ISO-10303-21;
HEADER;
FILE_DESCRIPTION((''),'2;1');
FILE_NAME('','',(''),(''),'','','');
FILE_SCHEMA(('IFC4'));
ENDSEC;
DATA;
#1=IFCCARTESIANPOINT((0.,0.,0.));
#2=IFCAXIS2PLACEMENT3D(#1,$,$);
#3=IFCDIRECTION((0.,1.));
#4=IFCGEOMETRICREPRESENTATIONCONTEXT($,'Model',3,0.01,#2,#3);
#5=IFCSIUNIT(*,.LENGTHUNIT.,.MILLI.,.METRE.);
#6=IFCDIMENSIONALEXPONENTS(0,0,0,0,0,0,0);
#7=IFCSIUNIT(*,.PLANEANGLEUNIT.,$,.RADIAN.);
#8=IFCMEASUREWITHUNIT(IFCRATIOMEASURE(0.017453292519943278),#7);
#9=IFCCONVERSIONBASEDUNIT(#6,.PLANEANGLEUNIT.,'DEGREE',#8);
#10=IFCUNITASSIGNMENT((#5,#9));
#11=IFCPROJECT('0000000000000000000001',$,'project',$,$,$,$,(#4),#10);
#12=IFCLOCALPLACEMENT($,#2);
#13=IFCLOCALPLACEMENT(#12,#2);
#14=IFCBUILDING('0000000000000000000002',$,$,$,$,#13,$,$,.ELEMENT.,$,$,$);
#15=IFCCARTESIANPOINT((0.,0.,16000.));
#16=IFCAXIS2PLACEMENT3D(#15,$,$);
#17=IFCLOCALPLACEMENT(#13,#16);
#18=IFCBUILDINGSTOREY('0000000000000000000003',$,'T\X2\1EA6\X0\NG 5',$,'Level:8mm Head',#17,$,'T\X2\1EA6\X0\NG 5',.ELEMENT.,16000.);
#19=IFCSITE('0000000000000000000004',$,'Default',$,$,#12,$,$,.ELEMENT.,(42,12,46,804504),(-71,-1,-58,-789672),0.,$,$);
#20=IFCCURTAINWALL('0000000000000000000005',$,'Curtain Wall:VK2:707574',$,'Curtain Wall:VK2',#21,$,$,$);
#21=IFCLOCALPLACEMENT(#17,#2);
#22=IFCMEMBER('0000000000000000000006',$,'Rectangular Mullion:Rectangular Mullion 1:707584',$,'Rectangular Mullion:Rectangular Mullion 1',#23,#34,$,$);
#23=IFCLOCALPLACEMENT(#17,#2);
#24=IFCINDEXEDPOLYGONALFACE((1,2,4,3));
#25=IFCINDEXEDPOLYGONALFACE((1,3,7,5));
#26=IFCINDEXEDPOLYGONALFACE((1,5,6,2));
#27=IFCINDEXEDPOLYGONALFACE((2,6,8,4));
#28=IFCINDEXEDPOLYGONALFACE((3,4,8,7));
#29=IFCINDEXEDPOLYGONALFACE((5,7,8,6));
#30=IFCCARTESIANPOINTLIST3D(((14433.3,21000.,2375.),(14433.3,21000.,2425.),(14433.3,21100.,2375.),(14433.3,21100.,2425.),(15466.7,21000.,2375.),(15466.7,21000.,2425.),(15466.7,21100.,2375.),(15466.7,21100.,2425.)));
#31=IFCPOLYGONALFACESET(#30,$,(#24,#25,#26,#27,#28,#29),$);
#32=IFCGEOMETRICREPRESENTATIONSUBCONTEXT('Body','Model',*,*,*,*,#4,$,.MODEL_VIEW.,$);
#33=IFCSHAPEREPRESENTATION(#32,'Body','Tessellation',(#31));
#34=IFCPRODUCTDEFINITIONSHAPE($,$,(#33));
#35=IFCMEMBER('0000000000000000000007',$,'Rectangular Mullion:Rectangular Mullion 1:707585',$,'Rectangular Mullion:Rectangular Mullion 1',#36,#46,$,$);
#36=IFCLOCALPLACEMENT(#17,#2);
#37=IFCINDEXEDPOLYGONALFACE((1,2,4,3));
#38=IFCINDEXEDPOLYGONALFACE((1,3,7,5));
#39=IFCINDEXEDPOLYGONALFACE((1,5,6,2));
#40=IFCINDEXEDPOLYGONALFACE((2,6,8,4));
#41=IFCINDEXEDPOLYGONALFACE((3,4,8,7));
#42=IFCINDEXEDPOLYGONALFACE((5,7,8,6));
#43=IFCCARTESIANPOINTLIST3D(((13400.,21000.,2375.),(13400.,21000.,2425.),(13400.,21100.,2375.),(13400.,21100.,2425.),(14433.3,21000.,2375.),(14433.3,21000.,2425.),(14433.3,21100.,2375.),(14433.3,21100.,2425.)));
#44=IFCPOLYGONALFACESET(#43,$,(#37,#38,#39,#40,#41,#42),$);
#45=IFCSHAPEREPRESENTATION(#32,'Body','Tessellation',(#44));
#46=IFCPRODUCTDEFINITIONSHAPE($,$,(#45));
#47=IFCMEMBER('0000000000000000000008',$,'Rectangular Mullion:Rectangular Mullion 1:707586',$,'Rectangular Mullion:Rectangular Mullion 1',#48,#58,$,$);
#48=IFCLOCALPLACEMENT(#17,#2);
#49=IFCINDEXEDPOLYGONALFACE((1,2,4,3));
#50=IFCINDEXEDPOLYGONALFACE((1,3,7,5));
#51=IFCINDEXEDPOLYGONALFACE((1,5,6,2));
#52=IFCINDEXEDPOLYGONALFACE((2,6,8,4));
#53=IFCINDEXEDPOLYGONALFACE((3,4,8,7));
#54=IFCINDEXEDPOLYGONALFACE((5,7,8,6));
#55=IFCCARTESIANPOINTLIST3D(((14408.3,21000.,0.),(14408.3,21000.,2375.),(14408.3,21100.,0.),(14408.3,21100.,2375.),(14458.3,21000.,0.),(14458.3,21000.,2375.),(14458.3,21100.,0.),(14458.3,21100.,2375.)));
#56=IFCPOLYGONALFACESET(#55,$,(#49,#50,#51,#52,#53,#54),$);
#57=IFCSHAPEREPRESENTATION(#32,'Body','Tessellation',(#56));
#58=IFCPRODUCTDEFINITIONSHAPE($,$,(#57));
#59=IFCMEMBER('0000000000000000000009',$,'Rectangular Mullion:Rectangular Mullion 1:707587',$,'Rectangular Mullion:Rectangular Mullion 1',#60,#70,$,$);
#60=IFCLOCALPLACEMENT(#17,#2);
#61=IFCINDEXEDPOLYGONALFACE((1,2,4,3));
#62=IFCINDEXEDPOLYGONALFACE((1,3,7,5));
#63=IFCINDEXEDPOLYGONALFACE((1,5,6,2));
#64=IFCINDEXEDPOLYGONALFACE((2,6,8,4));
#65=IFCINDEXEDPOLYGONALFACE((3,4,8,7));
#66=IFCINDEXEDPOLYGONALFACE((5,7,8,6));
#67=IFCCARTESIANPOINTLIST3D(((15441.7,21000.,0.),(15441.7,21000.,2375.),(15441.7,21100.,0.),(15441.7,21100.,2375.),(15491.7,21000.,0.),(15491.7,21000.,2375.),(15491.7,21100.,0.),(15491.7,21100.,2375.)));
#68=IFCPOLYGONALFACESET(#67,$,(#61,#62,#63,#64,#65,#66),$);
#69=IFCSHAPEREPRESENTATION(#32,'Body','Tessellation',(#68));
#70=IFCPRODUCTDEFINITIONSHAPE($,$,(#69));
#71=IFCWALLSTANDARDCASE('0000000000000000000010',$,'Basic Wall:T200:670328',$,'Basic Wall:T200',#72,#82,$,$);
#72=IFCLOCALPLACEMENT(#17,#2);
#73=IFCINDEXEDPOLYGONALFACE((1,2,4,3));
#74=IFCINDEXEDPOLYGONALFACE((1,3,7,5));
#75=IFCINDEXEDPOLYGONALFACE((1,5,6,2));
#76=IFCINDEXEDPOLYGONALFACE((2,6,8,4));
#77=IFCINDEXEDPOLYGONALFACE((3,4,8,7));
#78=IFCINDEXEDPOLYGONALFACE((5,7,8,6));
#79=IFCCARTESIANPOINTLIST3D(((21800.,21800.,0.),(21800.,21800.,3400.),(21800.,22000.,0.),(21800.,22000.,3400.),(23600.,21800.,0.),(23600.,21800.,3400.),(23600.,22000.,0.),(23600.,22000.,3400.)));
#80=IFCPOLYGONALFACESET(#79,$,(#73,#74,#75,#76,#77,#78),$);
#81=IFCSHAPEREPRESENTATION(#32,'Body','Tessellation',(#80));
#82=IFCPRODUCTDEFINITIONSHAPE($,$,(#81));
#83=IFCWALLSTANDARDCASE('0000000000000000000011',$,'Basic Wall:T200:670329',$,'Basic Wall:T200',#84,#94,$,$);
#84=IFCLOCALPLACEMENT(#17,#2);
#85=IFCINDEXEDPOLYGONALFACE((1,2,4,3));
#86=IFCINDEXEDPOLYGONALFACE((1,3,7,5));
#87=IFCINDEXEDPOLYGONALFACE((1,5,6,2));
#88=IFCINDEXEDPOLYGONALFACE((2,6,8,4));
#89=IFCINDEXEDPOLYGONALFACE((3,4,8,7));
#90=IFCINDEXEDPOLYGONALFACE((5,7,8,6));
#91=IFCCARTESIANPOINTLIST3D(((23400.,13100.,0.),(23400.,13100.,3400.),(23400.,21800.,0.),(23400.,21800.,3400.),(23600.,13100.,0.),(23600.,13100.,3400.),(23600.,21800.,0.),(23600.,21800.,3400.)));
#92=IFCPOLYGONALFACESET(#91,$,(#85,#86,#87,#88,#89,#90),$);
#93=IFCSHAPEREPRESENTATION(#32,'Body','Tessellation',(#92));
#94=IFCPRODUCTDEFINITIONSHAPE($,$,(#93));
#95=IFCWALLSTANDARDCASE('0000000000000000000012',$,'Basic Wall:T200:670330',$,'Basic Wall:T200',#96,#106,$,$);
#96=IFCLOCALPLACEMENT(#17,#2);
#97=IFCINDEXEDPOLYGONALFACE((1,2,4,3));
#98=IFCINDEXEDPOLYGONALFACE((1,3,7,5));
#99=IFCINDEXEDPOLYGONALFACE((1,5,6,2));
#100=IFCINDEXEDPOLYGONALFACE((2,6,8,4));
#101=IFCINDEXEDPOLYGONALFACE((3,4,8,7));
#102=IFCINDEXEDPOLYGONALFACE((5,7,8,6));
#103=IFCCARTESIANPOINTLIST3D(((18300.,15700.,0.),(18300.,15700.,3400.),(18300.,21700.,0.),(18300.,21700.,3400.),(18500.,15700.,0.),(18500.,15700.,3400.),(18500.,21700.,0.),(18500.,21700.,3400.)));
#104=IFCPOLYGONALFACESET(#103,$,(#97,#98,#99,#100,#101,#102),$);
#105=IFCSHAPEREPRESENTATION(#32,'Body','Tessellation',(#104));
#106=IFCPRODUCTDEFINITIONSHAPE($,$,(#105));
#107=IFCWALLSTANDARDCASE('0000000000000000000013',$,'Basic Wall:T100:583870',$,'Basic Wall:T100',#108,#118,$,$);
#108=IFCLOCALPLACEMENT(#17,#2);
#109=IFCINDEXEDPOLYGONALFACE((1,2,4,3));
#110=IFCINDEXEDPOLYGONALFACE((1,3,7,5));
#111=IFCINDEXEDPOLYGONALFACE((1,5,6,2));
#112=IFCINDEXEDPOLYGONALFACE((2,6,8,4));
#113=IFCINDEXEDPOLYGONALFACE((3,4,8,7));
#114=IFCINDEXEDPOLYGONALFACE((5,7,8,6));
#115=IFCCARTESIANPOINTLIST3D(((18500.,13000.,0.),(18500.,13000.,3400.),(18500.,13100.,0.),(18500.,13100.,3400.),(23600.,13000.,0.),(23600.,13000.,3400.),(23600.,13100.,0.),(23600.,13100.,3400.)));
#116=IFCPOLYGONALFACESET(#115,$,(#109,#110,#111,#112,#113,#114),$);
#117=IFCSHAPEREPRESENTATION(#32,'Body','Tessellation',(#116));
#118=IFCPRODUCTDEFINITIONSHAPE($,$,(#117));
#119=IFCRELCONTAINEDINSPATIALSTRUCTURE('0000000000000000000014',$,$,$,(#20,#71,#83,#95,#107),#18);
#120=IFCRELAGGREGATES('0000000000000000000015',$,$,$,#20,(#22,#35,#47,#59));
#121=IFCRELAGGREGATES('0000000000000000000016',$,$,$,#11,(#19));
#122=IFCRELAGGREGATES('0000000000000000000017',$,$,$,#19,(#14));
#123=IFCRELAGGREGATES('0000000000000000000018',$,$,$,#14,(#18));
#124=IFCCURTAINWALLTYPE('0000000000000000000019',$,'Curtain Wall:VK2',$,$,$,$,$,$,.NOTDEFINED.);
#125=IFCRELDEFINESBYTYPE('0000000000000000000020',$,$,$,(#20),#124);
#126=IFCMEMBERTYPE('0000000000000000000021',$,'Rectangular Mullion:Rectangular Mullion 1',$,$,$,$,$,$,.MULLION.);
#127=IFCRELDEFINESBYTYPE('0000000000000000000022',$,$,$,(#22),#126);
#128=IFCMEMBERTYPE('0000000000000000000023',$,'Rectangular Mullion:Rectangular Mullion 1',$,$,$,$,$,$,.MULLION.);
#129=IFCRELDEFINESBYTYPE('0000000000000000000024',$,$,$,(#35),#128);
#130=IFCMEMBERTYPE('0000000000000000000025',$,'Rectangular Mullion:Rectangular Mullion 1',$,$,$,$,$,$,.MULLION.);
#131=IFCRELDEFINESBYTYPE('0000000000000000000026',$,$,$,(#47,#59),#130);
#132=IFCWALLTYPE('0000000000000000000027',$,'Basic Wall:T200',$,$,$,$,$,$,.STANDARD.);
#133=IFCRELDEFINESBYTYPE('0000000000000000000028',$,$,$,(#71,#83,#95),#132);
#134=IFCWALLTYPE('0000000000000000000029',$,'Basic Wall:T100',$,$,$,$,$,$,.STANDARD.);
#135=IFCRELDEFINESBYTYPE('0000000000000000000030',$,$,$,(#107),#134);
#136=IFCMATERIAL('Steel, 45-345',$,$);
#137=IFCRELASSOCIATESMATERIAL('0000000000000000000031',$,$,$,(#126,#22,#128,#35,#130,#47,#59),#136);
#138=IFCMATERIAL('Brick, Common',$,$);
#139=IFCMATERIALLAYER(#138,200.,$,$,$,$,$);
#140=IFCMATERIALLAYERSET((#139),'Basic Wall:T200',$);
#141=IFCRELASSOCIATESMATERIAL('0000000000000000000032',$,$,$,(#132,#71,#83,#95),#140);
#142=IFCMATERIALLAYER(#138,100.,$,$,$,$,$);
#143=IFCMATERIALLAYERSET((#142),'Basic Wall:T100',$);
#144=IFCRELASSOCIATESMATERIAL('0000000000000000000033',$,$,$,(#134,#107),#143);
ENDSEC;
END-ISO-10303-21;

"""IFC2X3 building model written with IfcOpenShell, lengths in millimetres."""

from ifc_helpers import new_model, entity, si_unit, converted_unit, direction, frame, frame_2d, origin, origin_2d_with_axis, place, context, subcontext, project, spatial, rectangle, extrude, source, transform, mapped, material, layer, layer_set, layer_usage, type_object, type_shapes, element, aggregate, save


model = new_model("IFC2X3")

# Units and contexts
model_context = context("Model", 3, precision=0.01, world=origin(), true_north=direction((0.0, 1.0)))
body_context = subcontext(model_context, "Body", "Model", "MODEL_VIEW")
ifc_project = project(units=[si_unit("LENGTHUNIT", "METRE", prefix="MILLI"), converted_unit("PLANEANGLEUNIT", "DEGREE", entity("IfcRatioMeasure", 0.017453292519943278), si_unit("PLANEANGLEUNIT", "RADIAN"), dimensions=[0, 0, 0, 0, 0, 0, 0])], contexts=[model_context])

# Site, building, storey
site_placement = place(None, origin())
site = spatial("IfcSite", under=ifc_project, at=site_placement, Name="Default", CompositionType="ELEMENT", RefLatitude=(42, 12, 46, 804504), RefLongitude=(-71, -1, -58, -789672), RefElevation=0.0)
building_placement = place(site_placement, origin())
building = spatial("IfcBuilding", under=site, at=building_placement, CompositionType="ELEMENT")
storey_placement = place(building_placement, frame((0.0, 0.0, 16000.0)))
storey = spatial("IfcBuildingStorey", under=building, at=storey_placement, Name="TẦNG 5", ObjectType="Level:8mm Head", LongName="TẦNG 5", CompositionType="ELEMENT", Elevation=16000.0)

# Curtain wall, members
curtain_wall_type = type_object("IfcCurtainWallType", Name="Curtain Wall:VK2", PredefinedType="NOTDEFINED")
curtain_wall_placement = place(storey_placement, frame((0.0, 0.0, -16000.0)))
curtain_wall = element("IfcCurtainWall", 1, at=curtain_wall_placement, inside=storey, type_object=curtain_wall_type, Name="Curtain Wall:VK2:707574", ObjectType="Curtain Wall:VK2")
ifc_material_1 = material(Name="Steel, 45-345")
member_type_1 = type_object("IfcMemberType", Name="Rectangular Mullion:Rectangular Mullion 1", PredefinedType="MULLION", material=ifc_material_1)
shared_shape_1 = source(origin(), body_context, "Body", "SweptSolid", [
    extrude(rectangle(XDim=100.0, YDim=50.0, at=origin_2d_with_axis()), frame((0.0, 50.0, -1033.3), z_axis=(0.0, 0.0, 1.0), x_axis=(0.0, -1.0, 0.0)), (0.0, 0.0, 1.0), 1033.3),
])
type_shapes(member_type_1, [shared_shape_1])
member_1_placement = place(curtain_wall_placement, frame((15466.7, 21100.0, 18400.0), z_axis=(1.0, 0.0, 0.0), x_axis=(0.0, 0.0, 1.0)))
member_1 = element("IfcMember", 2, at=member_1_placement, type_object=member_type_1, material=ifc_material_1, Name="Rectangular Mullion:Rectangular Mullion 1:707584", ObjectType="Rectangular Mullion:Rectangular Mullion 1", context=body_context, shape_type="MappedRepresentation", body=[
    mapped(shared_shape_1, transform((0.0, 0.0, 0.0), scale=1.0)),
])
member_type_2 = type_object("IfcMemberType", Name="Rectangular Mullion:Rectangular Mullion 1", PredefinedType="MULLION", material=ifc_material_1)
shared_shape_2 = source(origin(), body_context, "Body", "SweptSolid", [
    extrude(rectangle(XDim=100.0, YDim=50.0, at=origin_2d_with_axis()), frame((0.0, 50.0, -1033.3), z_axis=(0.0, 0.0, 1.0), x_axis=(0.0, -1.0, 0.0)), (0.0, 0.0, 1.0), 1033.3),
])
type_shapes(member_type_2, [shared_shape_2])
member_2_placement = place(curtain_wall_placement, frame((14433.3, 21100.0, 18400.0), z_axis=(1.0, 0.0, 0.0), x_axis=(0.0, 0.0, 1.0)))
member_2 = element("IfcMember", 3, at=member_2_placement, type_object=member_type_2, material=ifc_material_1, Name="Rectangular Mullion:Rectangular Mullion 1:707585", ObjectType="Rectangular Mullion:Rectangular Mullion 1", context=body_context, shape_type="MappedRepresentation", body=[
    mapped(shared_shape_2, transform((0.0, 0.0, 0.0), scale=1.0)),
])
member_type_3 = type_object("IfcMemberType", Name="Rectangular Mullion:Rectangular Mullion 1", PredefinedType="MULLION", material=ifc_material_1)
shared_shape_3 = source(origin(), body_context, "Body", "SweptSolid", [
    extrude(rectangle(XDim=100.0, YDim=50.0, at=origin_2d_with_axis()), frame((0.0, 50.0, -2375.0), z_axis=(0.0, 0.0, 1.0), x_axis=(0.0, -1.0, 0.0)), (0.0, 0.0, 1.0), 2375.0),
])
type_shapes(member_type_3, [shared_shape_3])
member_3_placement = place(curtain_wall_placement, frame((14433.3, 21100.0, 16000.0), z_axis=(0.0, 0.0, -1.0), x_axis=(1.0, 0.0, 0.0)))
member_3 = element("IfcMember", 4, at=member_3_placement, type_object=member_type_3, material=ifc_material_1, Name="Rectangular Mullion:Rectangular Mullion 1:707586", ObjectType="Rectangular Mullion:Rectangular Mullion 1", context=body_context, shape_type="MappedRepresentation", body=[
    mapped(shared_shape_3, transform((0.0, 0.0, 0.0), scale=1.0)),
])
member_4_placement = place(curtain_wall_placement, frame((15466.7, 21100.0, 16000.0), z_axis=(0.0, 0.0, -1.0), x_axis=(1.0, 0.0, 0.0)))
member_4 = element("IfcMember", 5, at=member_4_placement, type_object=member_type_3, material=ifc_material_1, Name="Rectangular Mullion:Rectangular Mullion 1:707587", ObjectType="Rectangular Mullion:Rectangular Mullion 1", context=body_context, shape_type="MappedRepresentation", body=[
    mapped(shared_shape_3, transform((0.0, 0.0, 0.0), scale=1.0)),
])
aggregate(curtain_wall, [member_1, member_2, member_3, member_4])

# Walls
ifc_material_2 = material(Name="Brick, Common")
ifc_layer_1 = layer(ifc_material_2, 200.0)
ifc_layer_set_1 = layer_set([ifc_layer_1], Name="Basic Wall:T200")
ifc_layer_usage_1 = layer_usage(ifc_layer_set_1, "AXIS2", "NEGATIVE", 100.0)
wall_type_1 = type_object("IfcWallType", Name="Basic Wall:T200", PredefinedType="STANDARD", material=ifc_layer_set_1)
wall_1_placement = place(storey_placement, frame((21800.0, 21900.0, 0.0)))
element("IfcWallStandardCase", 6, at=wall_1_placement, inside=storey, type_object=wall_type_1, material=ifc_layer_usage_1, Name="Basic Wall:T200:670328", ObjectType="Basic Wall:T200", context=body_context, shape_type="SweptSolid", body=[
    extrude(rectangle(XDim=1800.0, YDim=200.0, at=frame_2d((900.0, 0.0), x_axis=(-1.0, 0.0))), origin(), (0.0, 0.0, 1.0), 3400.0),
])
wall_2_placement = place(storey_placement, frame((23500.0, 21800.0, 0.0), z_axis=(0.0, 0.0, 1.0), x_axis=(0.0, -1.0, 0.0)))
element("IfcWallStandardCase", 7, at=wall_2_placement, inside=storey, type_object=wall_type_1, material=ifc_layer_usage_1, Name="Basic Wall:T200:670329", ObjectType="Basic Wall:T200", context=body_context, shape_type="SweptSolid", body=[
    extrude(rectangle(XDim=8700.0, YDim=200.0, at=frame_2d((4350.0, 0.0), x_axis=(-1.0, 0.0))), origin(), (0.0, 0.0, 1.0), 3400.0),
])
wall_3_placement = place(storey_placement, frame((18400.0, 15700.0, 0.0), z_axis=(0.0, 0.0, 1.0), x_axis=(0.0, 1.0, 0.0)))
element("IfcWallStandardCase", 8, at=wall_3_placement, inside=storey, type_object=wall_type_1, material=ifc_layer_usage_1, Name="Basic Wall:T200:670330", ObjectType="Basic Wall:T200", context=body_context, shape_type="SweptSolid", body=[
    extrude(rectangle(XDim=6000.0, YDim=200.0, at=frame_2d((3000.0, 0.0), x_axis=(-1.0, 0.0))), origin(), (0.0, 0.0, 1.0), 3400.0),
])
ifc_layer_2 = layer(ifc_material_2, 100.0)
ifc_layer_set_2 = layer_set([ifc_layer_2], Name="Basic Wall:T100")
ifc_layer_usage_2 = layer_usage(ifc_layer_set_2, "AXIS2", "POSITIVE", -50.0)
wall_type_2 = type_object("IfcWallType", Name="Basic Wall:T100", PredefinedType="STANDARD", material=ifc_layer_set_2)
wall_4_placement = place(storey_placement, frame((18500.0, 13050.0, 0.0)))
element("IfcWallStandardCase", 9, at=wall_4_placement, inside=storey, type_object=wall_type_2, material=ifc_layer_usage_2, Name="Basic Wall:T100:583870", ObjectType="Basic Wall:T100", context=body_context, shape_type="SweptSolid", body=[
    extrude(rectangle(XDim=5100.0, YDim=100.0, at=frame_2d((2550.0, 0.0), x_axis=(-1.0, 0.0))), origin(), (0.0, 0.0, 1.0), 3400.0),
])

save(model, "model.ifc")
